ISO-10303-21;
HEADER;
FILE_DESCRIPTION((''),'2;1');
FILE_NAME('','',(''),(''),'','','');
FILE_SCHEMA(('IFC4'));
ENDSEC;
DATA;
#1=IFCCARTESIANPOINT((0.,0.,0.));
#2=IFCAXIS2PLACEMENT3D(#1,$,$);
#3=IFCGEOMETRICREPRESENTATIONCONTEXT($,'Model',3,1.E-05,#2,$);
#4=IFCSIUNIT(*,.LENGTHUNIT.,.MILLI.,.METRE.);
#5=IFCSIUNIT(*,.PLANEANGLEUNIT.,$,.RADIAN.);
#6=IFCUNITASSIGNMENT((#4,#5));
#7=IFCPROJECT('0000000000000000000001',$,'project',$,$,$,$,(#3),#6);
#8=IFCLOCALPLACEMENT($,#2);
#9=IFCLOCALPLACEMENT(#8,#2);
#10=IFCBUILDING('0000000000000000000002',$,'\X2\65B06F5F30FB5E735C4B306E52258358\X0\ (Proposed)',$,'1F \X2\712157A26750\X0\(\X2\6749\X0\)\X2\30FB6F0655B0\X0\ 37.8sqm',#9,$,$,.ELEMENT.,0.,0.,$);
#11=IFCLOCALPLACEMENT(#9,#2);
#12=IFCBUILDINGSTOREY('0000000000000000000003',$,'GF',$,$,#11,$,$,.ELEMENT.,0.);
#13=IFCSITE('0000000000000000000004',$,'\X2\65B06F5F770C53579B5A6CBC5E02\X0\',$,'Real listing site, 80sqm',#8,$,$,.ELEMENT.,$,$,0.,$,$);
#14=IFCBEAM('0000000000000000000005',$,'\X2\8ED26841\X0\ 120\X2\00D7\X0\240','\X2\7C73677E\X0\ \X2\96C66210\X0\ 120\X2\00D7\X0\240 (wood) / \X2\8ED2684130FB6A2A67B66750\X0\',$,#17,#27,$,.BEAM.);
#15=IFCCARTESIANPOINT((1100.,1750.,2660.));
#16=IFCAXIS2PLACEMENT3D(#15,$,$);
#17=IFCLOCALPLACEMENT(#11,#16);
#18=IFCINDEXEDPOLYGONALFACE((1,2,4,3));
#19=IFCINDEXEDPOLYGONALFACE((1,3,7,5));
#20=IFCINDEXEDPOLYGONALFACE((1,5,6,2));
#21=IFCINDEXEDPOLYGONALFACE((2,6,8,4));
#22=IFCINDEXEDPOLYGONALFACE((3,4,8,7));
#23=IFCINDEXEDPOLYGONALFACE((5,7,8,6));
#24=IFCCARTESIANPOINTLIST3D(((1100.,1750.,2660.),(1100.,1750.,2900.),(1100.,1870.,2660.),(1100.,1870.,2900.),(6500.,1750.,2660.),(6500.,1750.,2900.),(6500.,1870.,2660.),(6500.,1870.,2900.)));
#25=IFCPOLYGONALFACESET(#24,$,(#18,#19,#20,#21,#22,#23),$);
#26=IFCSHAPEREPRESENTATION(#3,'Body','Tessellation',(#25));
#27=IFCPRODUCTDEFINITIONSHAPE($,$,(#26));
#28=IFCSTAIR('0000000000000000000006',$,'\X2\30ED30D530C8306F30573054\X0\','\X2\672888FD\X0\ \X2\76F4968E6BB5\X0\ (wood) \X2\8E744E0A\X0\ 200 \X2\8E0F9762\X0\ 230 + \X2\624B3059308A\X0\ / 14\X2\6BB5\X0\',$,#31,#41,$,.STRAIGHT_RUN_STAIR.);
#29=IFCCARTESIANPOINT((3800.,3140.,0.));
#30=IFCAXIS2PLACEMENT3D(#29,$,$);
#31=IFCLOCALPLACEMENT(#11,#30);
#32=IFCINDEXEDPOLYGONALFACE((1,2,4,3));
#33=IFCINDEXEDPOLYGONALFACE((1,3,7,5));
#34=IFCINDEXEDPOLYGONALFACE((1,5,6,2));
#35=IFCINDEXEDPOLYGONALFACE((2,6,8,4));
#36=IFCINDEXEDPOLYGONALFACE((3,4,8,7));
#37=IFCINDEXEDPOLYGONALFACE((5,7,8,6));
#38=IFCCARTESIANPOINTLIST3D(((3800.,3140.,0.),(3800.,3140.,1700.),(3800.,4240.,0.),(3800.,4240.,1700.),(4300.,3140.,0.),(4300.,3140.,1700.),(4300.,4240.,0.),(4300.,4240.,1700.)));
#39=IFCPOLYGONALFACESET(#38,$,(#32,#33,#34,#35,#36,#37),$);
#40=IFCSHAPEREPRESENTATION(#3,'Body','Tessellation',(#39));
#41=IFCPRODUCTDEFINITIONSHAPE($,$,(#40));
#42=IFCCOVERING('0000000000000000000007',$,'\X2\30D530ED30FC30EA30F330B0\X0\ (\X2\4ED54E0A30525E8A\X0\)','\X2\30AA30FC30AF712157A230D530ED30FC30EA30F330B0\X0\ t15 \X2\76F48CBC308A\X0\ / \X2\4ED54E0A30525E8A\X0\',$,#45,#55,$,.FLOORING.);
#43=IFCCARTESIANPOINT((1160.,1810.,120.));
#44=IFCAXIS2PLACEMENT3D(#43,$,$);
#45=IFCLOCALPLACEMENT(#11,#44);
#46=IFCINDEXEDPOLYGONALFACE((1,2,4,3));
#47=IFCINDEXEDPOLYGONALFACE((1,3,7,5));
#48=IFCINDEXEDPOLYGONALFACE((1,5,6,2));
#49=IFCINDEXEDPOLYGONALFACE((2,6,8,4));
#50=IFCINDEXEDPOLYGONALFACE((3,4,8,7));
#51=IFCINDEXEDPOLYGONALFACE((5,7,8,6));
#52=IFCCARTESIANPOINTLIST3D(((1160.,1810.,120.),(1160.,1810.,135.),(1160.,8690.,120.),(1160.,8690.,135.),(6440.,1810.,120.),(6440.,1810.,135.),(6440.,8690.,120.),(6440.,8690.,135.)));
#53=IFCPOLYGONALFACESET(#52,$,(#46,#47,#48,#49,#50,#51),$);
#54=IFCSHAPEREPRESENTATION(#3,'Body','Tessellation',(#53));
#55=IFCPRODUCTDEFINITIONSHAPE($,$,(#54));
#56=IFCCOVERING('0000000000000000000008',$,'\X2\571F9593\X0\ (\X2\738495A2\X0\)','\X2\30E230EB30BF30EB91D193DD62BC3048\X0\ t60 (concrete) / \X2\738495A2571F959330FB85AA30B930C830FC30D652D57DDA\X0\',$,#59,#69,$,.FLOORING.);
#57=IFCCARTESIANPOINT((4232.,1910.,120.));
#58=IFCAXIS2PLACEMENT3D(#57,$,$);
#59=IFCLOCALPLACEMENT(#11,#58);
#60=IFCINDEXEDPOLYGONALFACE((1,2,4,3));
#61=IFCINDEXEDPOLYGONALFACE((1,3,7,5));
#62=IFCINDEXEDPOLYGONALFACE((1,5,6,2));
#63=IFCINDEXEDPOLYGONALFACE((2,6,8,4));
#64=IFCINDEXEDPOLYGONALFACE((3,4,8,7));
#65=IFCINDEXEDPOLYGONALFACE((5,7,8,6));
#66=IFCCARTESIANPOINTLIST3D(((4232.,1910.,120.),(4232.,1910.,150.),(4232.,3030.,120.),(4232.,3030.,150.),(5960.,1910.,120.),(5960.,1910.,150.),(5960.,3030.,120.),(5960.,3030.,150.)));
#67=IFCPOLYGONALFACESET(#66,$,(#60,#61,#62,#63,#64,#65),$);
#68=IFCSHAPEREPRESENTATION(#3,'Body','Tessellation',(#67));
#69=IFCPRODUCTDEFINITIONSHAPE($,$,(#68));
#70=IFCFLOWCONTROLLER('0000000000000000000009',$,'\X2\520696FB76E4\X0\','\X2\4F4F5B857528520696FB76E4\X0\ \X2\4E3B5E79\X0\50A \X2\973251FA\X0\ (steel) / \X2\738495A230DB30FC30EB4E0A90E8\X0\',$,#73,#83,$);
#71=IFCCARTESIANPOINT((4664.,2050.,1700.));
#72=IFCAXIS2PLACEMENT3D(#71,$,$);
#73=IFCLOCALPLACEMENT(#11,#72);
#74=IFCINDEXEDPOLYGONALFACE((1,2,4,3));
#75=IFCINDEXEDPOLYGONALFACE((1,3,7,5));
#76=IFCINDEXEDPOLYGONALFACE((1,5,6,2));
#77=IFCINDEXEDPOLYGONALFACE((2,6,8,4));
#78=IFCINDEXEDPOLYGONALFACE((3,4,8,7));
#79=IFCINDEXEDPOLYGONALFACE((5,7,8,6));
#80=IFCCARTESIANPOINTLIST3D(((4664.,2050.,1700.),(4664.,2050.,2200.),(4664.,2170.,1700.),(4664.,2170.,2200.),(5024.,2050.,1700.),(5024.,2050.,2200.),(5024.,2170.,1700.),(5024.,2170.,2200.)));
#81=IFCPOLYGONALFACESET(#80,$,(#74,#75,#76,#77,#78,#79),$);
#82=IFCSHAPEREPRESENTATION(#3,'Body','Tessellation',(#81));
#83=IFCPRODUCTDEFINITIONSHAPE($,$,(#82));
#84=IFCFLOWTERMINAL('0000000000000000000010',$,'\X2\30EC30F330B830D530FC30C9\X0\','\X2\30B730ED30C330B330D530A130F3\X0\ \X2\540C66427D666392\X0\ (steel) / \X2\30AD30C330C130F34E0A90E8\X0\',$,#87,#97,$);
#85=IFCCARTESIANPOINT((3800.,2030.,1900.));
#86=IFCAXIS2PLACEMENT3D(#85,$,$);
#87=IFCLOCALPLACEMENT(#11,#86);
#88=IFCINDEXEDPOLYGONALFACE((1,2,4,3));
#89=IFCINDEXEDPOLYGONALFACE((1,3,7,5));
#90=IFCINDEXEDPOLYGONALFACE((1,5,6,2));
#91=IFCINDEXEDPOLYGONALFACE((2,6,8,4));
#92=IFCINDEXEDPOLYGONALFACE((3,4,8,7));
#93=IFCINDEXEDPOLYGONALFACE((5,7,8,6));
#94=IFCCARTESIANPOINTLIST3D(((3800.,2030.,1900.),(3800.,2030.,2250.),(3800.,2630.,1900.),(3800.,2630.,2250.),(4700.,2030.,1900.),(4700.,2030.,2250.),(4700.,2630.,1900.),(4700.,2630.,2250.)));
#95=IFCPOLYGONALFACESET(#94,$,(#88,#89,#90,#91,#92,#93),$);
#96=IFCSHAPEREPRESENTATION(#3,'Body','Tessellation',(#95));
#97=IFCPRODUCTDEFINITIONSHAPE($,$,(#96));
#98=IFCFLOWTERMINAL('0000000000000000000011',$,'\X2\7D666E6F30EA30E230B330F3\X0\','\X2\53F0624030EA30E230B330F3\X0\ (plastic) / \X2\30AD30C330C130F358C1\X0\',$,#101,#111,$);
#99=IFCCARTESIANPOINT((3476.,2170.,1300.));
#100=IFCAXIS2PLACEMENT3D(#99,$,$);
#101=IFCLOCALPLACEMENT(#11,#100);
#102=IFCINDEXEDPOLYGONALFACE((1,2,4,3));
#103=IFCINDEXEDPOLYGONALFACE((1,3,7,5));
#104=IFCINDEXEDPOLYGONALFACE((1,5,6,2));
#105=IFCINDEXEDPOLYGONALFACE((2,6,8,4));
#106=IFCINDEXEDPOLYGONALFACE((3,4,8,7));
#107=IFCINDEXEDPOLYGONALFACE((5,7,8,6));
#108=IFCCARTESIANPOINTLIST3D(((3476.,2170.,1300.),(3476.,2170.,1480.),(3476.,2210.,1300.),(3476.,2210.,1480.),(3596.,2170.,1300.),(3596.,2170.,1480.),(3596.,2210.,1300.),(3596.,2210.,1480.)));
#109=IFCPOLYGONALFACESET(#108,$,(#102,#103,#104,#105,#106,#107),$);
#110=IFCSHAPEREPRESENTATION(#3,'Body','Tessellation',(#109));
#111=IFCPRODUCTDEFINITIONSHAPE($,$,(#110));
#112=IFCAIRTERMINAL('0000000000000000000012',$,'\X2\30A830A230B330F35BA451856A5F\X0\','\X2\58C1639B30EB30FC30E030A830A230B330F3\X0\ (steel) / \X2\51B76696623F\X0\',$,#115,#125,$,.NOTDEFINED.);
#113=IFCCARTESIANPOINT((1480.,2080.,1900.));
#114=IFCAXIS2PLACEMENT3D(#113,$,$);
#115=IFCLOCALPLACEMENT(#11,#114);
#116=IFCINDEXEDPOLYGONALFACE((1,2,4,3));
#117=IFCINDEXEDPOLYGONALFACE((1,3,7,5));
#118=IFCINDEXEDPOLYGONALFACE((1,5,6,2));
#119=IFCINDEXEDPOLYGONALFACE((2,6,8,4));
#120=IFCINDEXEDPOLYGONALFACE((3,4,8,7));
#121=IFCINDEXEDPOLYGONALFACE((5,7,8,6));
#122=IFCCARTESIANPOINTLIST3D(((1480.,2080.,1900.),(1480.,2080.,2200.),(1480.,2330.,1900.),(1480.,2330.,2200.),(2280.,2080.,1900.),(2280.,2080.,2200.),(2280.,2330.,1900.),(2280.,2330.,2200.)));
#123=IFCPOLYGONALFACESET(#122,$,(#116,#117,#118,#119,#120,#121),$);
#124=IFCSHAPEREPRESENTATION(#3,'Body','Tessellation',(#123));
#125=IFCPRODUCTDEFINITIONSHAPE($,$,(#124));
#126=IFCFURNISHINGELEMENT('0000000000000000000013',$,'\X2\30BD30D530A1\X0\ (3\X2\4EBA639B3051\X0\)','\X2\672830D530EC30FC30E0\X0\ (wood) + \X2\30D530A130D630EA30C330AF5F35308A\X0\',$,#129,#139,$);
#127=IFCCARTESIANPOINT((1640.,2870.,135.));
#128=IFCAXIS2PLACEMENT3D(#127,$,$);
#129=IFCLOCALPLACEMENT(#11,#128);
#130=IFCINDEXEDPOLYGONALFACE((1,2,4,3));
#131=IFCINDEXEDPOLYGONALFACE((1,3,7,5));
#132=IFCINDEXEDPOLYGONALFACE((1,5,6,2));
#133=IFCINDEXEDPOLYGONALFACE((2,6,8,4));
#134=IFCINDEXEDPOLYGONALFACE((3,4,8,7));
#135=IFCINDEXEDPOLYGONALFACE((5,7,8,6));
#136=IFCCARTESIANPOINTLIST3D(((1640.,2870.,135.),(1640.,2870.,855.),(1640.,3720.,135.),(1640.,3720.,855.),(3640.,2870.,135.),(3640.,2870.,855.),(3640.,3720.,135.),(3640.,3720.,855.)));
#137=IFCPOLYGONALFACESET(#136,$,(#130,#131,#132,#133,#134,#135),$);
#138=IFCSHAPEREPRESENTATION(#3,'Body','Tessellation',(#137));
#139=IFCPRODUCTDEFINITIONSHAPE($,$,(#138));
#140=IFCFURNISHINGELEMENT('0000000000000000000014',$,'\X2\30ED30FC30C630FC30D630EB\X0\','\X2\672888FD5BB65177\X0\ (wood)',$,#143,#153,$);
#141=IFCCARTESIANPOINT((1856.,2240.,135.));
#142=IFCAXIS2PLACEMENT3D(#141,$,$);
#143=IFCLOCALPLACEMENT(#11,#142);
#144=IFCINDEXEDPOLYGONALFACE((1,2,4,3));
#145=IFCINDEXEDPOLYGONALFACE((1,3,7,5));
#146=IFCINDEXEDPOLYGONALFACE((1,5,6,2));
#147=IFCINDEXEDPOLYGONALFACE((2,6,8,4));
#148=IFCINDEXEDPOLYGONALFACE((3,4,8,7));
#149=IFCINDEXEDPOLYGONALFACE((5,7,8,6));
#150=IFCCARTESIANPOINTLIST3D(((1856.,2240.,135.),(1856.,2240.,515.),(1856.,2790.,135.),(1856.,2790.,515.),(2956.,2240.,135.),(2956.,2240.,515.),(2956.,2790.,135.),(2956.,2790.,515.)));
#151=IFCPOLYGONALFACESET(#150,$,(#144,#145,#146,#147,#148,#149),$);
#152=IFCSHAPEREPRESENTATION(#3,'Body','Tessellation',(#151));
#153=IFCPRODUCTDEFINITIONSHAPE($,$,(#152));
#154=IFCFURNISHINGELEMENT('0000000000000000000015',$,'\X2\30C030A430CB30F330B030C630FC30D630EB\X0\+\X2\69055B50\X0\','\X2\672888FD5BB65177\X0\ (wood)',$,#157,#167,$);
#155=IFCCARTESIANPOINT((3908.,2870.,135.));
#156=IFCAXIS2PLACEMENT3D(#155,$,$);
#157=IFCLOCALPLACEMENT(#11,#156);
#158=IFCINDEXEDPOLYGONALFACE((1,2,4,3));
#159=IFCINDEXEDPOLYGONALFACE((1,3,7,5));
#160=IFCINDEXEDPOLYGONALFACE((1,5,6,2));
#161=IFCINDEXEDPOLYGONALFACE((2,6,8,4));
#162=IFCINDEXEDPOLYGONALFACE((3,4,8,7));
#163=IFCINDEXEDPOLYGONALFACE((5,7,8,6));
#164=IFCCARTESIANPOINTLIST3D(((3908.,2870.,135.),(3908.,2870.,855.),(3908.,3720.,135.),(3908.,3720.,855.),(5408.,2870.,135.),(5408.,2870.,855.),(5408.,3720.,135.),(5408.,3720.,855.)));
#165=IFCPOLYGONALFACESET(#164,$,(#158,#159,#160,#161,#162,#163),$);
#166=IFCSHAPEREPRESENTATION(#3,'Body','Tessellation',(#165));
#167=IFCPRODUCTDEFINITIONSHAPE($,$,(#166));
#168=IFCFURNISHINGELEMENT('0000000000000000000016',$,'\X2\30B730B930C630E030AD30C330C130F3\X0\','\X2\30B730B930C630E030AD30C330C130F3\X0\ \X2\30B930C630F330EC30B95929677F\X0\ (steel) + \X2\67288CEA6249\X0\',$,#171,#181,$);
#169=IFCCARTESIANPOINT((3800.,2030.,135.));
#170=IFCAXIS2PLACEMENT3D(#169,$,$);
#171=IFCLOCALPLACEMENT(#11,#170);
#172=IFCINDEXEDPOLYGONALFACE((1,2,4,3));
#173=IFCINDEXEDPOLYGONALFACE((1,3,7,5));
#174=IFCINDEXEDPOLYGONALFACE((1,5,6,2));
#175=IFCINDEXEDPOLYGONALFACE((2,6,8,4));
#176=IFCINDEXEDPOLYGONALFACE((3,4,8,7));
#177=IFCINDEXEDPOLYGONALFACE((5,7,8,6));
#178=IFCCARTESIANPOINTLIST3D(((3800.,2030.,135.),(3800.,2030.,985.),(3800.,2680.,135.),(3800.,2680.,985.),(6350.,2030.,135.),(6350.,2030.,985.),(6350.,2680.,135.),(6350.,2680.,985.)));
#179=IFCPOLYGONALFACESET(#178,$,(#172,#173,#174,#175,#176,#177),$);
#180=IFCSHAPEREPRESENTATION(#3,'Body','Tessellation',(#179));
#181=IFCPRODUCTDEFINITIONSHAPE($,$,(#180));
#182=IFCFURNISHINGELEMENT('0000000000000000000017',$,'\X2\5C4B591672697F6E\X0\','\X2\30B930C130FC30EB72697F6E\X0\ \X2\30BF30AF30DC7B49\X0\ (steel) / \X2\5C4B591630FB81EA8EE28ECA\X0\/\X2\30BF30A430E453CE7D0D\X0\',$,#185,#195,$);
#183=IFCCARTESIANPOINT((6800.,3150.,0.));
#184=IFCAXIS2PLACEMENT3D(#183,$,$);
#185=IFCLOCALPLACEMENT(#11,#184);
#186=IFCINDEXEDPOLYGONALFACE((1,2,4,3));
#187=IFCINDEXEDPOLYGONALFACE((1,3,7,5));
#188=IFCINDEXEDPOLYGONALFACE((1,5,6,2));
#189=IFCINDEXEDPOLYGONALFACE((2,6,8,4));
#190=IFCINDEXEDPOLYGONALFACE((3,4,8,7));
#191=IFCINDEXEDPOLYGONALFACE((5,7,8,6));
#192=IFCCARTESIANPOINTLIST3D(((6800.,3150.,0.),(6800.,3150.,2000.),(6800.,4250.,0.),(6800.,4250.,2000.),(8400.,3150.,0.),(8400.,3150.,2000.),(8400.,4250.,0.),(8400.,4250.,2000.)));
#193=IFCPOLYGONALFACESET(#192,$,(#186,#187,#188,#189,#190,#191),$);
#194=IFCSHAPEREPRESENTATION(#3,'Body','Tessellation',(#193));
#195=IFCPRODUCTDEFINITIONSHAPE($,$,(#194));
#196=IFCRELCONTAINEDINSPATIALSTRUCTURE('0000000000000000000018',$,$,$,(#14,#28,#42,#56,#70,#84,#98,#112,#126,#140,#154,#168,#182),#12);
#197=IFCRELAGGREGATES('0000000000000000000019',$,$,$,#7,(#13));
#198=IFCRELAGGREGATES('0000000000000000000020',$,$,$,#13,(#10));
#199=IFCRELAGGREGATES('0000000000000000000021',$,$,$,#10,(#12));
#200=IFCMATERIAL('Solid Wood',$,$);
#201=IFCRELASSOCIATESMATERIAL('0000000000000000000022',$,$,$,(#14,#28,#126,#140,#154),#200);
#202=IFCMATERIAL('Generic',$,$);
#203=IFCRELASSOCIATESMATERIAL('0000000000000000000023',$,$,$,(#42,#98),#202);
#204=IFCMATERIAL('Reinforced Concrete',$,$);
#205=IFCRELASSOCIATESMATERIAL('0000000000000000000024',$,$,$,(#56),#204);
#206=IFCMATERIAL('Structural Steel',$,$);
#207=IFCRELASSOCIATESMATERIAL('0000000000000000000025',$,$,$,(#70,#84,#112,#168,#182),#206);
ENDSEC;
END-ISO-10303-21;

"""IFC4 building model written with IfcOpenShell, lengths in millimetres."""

from ifc_helpers import new_model, si_unit, frame, frame_2d, origin, place, context, project, spatial, rectangle, extrude, material, element, save


model = new_model("IFC4")

# Units and contexts
model_context = context("Model", 3, precision=1e-05, world=origin())
ifc_project = project(units=[si_unit("LENGTHUNIT", "METRE", prefix="MILLI"), si_unit("PLANEANGLEUNIT", "RADIAN")], contexts=[model_context])

# Site, building, storey
site_placement = place(None, origin())
site = spatial("IfcSite", under=ifc_project, at=site_placement, Name="新潟県南魚沼市", ObjectType="Real listing site, 80sqm", CompositionType="ELEMENT", RefElevation=0.0)
building_placement = place(site_placement, origin())
building = spatial("IfcBuilding", under=site, at=building_placement, Name="新潟・平屋の別荘 (Proposed)", ObjectType="1F 無垢材(杉)・漆喰 37.8sqm", CompositionType="ELEMENT", ElevationOfRefHeight=0.0, ElevationOfTerrain=0.0)
storey_placement = place(building_placement, origin())
storey = spatial("IfcBuildingStorey", under=building, at=storey_placement, Name="GF", CompositionType="ELEMENT", Elevation=0.0)

# Beam
ifc_material_1 = material(Name="Solid Wood")
beam_1_placement = place(storey_placement, frame((1100.0, 1750.0, 2660.0)))
element("IfcBeam", 1, at=beam_1_placement, inside=storey, material=ifc_material_1, Name="軒桁 120×240", Description="米松 集成 120×240 (wood) / 軒桁・横架材", PredefinedType="BEAM", context=model_context, shape_type="SweptSolid", body=[
    extrude(rectangle(XDim=5400.0, YDim=120.0, at=frame_2d((2700.0, 60.0))), frame((1100.0, 1750.0, 2660.0)), (0.0, 0.0, 1.0), 240.0),
])

# Stair
stair_placement = place(storey_placement, frame((3800.0, 3140.0, 0.0)))
element("IfcStair", 2, at=stair_placement, inside=storey, material=ifc_material_1, Name="ロフトはしご", Description="木製 直階段 (wood) 蹴上 200 踏面 230 + 手すり / 14段", PredefinedType="STRAIGHT_RUN_STAIR", context=model_context, shape_type="SweptSolid", body=[
    extrude(rectangle(XDim=500.0, YDim=1100.0, at=frame_2d((250.0, 550.0))), frame((3800.0, 3140.0, 0.0)), (0.0, 0.0, 1.0), 1700.0),
])

# Coverings
ifc_material_2 = material(Name="Generic")
covering_1_placement = place(storey_placement, frame((1160.0, 1810.0, 120.0)))
element("IfcCovering", 3, at=covering_1_placement, inside=storey, material=ifc_material_2, Name="フローリング (仕上げ床)", Description="オーク無垢フローリング t15 直貼り / 仕上げ床", PredefinedType="FLOORING", context=model_context, shape_type="SweptSolid", body=[
    extrude(rectangle(XDim=5280.0, YDim=6880.0, at=frame_2d((2640.0, 3440.0))), frame((1160.0, 1810.0, 120.0)), (0.0, 0.0, 1.0), 15.0),
])
ifc_material_3 = material(Name="Reinforced Concrete")
covering_2_placement = place(storey_placement, frame((4232.0, 1910.0, 120.0)))
element("IfcCovering", 4, at=covering_2_placement, inside=storey, material=ifc_material_3, Name="土間 (玄関)", Description="モルタル金鏝押え t60 (concrete) / 玄関土間・薪ストーブ動線", PredefinedType="FLOORING", context=model_context, shape_type="SweptSolid", body=[
    extrude(rectangle(XDim=1728.0, YDim=1120.0, at=frame_2d((864.0, 560.0))), frame((4232.0, 1910.0, 120.0)), (0.0, 0.0, 1.0), 30.0),
])

# Flow controller
ifc_material_4 = material(Name="Structural Steel")
flow_controller_placement = place(storey_placement, frame((4664.0, 2050.0, 1700.0)))
element("IfcFlowController", 5, at=flow_controller_placement, inside=storey, material=ifc_material_4, Name="分電盤", Description="住宅用分電盤 主幹50A 露出 (steel) / 玄関ホール上部", context=model_context, shape_type="SweptSolid", body=[
    extrude(rectangle(XDim=360.0, YDim=120.0, at=frame_2d((180.0, 60.0))), frame((4664.0, 2050.0, 1700.0)), (0.0, 0.0, 1.0), 500.0),
])

# Flow terminals
flow_terminal_1_placement = place(storey_placement, frame((3800.0, 2030.0, 1900.0)))
element("IfcFlowTerminal", 6, at=flow_terminal_1_placement, inside=storey, material=ifc_material_4, Name="レンジフード", Description="シロッコファン 同時給排 (steel) / キッチン上部", context=model_context, shape_type="SweptSolid", body=[
    extrude(rectangle(XDim=900.0, YDim=600.0, at=frame_2d((450.0, 300.0))), frame((3800.0, 2030.0, 1900.0)), (0.0, 0.0, 1.0), 350.0),
])
flow_terminal_2_placement = place(storey_placement, frame((3476.0, 2170.0, 1300.0)))
element("IfcFlowTerminal", 7, at=flow_terminal_2_placement, inside=storey, material=ifc_material_2, Name="給湯リモコン", Description="台所リモコン (plastic) / キッチン壁", context=model_context, shape_type="SweptSolid", body=[
    extrude(rectangle(XDim=120.0, YDim=40.0, at=frame_2d((60.0, 20.0))), frame((3476.0, 2170.0, 1300.0)), (0.0, 0.0, 1.0), 180.0),
])

# Air terminal
air_terminal_placement = place(storey_placement, frame((1480.0, 2080.0, 1900.0)))
element("IfcAirTerminal", 8, at=air_terminal_placement, inside=storey, material=ifc_material_4, Name="エアコン室内機", Description="壁掛ルームエアコン (steel) / 冷暖房", PredefinedType="NOTDEFINED", context=model_context, shape_type="SweptSolid", body=[
    extrude(rectangle(XDim=800.0, YDim=250.0, at=frame_2d((400.0, 125.0))), frame((1480.0, 2080.0, 1900.0)), (0.0, 0.0, 1.0), 300.0),
])

# Furnishing elements
furnishing_1_placement = place(storey_placement, frame((1640.0, 2870.0, 135.0)))
element("IfcFurnishingElement", 9, at=furnishing_1_placement, inside=storey, material=ifc_material_1, Name="ソファ (3人掛け)", Description="木フレーム (wood) + ファブリック張り", context=model_context, shape_type="SweptSolid", body=[
    extrude(rectangle(XDim=2000.0, YDim=850.0, at=frame_2d((1000.0, 425.0))), frame((1640.0, 2870.0, 135.0)), (0.0, 0.0, 1.0), 720.0),
])
furnishing_2_placement = place(storey_placement, frame((1856.0, 2240.0, 135.0)))
element("IfcFurnishingElement", 10, at=furnishing_2_placement, inside=storey, material=ifc_material_1, Name="ローテーブル", Description="木製家具 (wood)", context=model_context, shape_type="SweptSolid", body=[
    extrude(rectangle(XDim=1100.0, YDim=550.0, at=frame_2d((550.0, 275.0))), frame((1856.0, 2240.0, 135.0)), (0.0, 0.0, 1.0), 380.0),
])
furnishing_3_placement = place(storey_placement, frame((3908.0, 2870.0, 135.0)))
element("IfcFurnishingElement", 11, at=furnishing_3_placement, inside=storey, material=ifc_material_1, Name="ダイニングテーブル+椅子", Description="木製家具 (wood)", context=model_context, shape_type="SweptSolid", body=[
    extrude(rectangle(XDim=1500.0, YDim=850.0, at=frame_2d((750.0, 425.0))), frame((3908.0, 2870.0, 135.0)), (0.0, 0.0, 1.0), 720.0),
])
furnishing_4_placement = place(storey_placement, frame((3800.0, 2030.0, 135.0)))
element("IfcFurnishingElement", 12, at=furnishing_4_placement, inside=storey, material=ifc_material_4, Name="システムキッチン", Description="システムキッチン ステンレス天板 (steel) + 木質扉", context=model_context, shape_type="SweptSolid", body=[
    extrude(rectangle(XDim=2550.0, YDim=650.0, at=frame_2d((1275.0, 325.0))), frame((3800.0, 2030.0, 135.0)), (0.0, 0.0, 1.0), 850.0),
])
furnishing_5_placement = place(storey_placement, frame((6800.0, 3150.0, 0.0)))
element("IfcFurnishingElement", 13, at=furnishing_5_placement, inside=storey, material=ifc_material_4, Name="屋外物置", Description="スチール物置 タクボ等 (steel) / 屋外・自転車/タイヤ収納", context=model_context, shape_type="SweptSolid", body=[
    extrude(rectangle(XDim=1600.0, YDim=1100.0, at=frame_2d((800.0, 550.0))), frame((6800.0, 3150.0, 0.0)), (0.0, 0.0, 1.0), 2000.0),
])

save(model, "model.ifc")
